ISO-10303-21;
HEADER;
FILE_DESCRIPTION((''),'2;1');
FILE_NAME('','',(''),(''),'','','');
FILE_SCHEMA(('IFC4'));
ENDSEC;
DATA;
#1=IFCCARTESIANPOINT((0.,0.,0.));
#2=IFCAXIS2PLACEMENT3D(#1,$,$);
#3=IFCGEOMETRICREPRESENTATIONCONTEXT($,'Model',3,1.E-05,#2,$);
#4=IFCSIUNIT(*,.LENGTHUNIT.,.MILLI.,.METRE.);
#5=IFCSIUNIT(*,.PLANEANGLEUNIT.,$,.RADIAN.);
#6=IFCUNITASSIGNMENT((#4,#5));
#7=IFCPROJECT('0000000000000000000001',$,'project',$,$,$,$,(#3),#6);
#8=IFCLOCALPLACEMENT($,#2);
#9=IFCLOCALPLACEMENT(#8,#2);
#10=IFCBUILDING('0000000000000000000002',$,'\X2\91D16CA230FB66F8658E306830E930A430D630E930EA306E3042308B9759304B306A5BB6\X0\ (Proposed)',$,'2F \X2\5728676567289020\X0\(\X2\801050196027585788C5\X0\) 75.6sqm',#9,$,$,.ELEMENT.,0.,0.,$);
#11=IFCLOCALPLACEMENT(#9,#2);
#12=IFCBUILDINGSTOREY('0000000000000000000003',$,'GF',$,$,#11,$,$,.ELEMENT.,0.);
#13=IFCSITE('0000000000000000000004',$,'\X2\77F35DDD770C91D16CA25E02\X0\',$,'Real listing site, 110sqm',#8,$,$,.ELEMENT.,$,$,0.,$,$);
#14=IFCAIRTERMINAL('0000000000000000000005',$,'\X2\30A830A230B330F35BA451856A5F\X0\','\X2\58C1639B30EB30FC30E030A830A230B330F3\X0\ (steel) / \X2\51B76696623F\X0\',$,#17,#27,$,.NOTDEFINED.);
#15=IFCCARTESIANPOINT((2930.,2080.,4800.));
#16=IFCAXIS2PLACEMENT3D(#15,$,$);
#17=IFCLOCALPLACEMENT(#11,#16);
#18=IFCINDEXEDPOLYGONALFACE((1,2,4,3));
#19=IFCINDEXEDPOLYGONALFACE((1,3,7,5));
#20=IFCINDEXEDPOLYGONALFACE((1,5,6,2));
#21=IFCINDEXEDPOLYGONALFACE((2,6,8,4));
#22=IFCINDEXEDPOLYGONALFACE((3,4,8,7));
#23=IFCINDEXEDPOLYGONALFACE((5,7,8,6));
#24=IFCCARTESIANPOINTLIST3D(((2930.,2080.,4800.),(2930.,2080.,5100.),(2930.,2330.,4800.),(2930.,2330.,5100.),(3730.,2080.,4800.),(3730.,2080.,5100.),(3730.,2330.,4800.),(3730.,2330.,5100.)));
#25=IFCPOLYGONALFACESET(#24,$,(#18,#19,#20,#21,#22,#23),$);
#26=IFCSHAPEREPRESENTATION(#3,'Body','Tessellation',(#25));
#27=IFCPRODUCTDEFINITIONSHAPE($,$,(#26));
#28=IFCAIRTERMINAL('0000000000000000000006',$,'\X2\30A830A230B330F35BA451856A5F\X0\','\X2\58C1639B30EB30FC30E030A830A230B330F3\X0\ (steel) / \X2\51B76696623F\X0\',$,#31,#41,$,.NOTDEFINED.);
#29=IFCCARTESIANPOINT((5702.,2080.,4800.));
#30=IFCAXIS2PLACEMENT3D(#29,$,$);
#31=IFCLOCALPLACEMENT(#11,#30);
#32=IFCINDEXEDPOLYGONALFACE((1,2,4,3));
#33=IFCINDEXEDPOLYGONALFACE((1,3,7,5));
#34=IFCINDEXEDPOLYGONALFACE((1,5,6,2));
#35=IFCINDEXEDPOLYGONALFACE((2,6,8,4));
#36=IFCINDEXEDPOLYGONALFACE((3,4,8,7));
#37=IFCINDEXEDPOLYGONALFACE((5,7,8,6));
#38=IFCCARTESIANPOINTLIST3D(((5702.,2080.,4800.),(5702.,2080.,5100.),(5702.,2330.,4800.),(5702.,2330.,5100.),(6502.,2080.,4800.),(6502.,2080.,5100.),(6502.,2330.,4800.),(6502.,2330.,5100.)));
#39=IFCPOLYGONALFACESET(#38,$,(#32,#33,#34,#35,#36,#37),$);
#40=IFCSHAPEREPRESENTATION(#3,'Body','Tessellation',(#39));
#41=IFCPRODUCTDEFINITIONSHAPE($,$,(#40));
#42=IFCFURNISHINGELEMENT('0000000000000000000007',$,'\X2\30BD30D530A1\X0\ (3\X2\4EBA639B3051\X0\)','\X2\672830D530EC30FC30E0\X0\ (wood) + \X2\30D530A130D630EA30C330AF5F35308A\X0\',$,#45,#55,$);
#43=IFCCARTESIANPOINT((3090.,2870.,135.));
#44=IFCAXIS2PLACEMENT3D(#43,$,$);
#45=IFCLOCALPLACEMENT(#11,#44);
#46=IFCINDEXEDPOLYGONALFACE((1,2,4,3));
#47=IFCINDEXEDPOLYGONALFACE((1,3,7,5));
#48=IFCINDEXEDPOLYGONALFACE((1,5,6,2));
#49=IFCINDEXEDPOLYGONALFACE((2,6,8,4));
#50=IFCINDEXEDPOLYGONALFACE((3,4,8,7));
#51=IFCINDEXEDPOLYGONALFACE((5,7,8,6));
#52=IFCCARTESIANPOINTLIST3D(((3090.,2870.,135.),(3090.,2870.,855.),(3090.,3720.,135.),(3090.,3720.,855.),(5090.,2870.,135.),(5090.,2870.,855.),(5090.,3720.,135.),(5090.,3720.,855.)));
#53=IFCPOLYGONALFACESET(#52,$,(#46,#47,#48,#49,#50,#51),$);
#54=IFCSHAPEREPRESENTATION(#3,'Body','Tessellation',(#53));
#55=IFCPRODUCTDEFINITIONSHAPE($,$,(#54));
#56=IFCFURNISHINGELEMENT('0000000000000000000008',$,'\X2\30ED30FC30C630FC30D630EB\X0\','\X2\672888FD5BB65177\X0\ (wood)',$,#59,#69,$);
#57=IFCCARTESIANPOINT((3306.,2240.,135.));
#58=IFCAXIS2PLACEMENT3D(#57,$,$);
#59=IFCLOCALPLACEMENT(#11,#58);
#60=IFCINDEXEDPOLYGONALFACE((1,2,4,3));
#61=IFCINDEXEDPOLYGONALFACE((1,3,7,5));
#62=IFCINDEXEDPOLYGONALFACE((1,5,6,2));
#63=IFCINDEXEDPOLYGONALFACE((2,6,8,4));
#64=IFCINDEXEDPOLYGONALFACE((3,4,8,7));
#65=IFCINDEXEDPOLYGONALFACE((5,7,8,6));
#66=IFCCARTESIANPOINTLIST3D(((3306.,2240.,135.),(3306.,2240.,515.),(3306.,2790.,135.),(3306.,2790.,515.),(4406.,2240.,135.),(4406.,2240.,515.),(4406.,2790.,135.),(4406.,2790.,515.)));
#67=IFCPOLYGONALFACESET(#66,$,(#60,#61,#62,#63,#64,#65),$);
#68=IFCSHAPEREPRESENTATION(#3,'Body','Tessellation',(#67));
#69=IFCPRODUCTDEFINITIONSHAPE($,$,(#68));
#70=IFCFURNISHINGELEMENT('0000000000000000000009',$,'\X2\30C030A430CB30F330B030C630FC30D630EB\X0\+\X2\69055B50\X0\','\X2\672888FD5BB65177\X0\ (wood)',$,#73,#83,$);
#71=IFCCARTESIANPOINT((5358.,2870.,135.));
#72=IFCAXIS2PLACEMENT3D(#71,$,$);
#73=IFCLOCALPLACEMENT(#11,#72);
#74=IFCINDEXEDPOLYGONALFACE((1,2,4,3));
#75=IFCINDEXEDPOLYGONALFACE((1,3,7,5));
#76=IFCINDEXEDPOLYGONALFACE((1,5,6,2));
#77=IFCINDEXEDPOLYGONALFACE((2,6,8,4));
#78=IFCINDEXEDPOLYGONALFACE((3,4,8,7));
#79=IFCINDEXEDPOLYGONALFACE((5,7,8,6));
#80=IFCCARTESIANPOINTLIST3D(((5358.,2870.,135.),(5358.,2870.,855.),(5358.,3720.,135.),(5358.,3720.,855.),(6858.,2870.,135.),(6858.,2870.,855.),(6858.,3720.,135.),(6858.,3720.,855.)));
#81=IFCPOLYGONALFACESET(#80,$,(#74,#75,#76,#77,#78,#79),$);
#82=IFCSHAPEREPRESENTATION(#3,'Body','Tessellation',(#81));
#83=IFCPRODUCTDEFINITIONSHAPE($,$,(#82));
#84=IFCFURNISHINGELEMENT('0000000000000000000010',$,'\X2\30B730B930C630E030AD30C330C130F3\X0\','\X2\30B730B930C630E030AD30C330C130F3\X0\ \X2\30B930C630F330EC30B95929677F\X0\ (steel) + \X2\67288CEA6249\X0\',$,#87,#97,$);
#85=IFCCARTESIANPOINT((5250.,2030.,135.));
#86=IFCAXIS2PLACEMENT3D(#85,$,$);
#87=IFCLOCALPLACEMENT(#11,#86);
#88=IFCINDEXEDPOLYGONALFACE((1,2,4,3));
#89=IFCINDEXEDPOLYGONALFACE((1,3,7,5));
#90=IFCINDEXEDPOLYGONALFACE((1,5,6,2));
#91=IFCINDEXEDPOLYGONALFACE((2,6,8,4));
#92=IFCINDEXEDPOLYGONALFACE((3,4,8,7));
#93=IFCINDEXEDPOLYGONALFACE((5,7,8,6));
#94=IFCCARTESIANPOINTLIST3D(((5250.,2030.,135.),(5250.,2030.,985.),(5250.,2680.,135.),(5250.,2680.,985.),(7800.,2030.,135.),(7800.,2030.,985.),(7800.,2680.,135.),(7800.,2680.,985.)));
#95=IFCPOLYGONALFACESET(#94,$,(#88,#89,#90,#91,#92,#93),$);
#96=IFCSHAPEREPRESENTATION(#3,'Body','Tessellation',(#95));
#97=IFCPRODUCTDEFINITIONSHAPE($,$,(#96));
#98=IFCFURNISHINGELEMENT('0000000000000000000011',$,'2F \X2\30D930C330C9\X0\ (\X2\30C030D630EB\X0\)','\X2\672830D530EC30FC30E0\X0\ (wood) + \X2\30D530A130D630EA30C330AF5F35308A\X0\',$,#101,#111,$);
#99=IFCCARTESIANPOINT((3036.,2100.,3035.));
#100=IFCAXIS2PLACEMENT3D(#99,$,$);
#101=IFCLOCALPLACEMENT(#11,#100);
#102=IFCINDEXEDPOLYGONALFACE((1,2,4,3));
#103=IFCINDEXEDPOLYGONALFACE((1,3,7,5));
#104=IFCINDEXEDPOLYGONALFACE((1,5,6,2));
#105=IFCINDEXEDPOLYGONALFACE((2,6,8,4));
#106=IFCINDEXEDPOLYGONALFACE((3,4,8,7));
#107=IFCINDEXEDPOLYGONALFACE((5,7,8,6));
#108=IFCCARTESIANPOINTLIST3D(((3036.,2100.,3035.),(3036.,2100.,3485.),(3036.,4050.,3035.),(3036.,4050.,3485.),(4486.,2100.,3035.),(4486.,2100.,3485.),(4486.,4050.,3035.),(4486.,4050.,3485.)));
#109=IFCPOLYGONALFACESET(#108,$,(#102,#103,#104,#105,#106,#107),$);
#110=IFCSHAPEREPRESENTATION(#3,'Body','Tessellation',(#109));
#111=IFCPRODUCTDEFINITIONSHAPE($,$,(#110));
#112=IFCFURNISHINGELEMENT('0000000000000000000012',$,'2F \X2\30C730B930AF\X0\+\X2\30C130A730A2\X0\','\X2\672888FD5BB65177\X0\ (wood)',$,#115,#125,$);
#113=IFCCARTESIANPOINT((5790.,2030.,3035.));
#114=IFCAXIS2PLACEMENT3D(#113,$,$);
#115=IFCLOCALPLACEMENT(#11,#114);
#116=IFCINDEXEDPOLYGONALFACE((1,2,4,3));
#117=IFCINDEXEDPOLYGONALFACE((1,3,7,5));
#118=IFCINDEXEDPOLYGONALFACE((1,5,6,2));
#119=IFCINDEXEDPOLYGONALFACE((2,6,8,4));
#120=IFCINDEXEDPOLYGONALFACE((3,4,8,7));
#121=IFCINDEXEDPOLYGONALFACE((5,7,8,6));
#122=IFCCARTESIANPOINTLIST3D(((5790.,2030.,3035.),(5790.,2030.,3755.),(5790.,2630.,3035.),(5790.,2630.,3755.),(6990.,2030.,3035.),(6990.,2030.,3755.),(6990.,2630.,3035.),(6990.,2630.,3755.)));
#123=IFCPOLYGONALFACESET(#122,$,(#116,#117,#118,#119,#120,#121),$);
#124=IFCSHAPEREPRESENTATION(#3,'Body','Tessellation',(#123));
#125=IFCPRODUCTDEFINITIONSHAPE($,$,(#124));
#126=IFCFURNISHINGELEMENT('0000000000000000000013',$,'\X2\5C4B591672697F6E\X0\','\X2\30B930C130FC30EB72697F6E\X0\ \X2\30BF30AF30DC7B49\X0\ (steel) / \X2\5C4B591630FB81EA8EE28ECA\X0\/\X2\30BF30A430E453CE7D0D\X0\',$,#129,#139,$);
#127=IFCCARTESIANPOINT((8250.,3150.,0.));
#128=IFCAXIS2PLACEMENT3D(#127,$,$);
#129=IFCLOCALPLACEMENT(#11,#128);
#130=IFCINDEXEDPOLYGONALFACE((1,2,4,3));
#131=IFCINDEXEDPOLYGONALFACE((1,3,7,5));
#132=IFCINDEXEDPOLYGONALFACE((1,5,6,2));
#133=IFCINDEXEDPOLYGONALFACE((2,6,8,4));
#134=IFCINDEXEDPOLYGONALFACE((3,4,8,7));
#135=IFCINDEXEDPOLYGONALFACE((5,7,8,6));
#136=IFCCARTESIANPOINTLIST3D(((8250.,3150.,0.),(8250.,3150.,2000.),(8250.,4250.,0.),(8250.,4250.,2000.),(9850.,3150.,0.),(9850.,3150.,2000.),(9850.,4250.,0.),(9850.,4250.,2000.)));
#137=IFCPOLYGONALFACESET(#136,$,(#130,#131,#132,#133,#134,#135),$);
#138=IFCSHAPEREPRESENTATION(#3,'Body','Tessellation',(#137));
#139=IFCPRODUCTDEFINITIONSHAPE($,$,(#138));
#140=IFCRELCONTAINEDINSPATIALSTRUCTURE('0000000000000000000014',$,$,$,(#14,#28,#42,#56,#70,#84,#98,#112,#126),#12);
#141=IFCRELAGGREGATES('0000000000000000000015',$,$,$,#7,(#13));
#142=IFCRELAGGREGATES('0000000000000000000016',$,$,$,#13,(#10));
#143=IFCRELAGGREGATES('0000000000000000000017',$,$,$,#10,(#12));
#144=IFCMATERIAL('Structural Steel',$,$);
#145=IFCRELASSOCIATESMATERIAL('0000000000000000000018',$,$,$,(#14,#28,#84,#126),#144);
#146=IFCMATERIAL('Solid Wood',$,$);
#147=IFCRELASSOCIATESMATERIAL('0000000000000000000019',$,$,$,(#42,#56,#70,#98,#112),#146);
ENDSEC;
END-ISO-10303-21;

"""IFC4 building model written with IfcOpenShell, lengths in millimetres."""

from ifc_helpers import new_model, si_unit, frame, frame_2d, origin, place, context, project, spatial, rectangle, extrude, material, element, save


model = new_model("IFC4")

# Units and contexts
model_context = context("Model", 3, precision=1e-05, world=origin())
ifc_project = project(units=[si_unit("LENGTHUNIT", "METRE", prefix="MILLI"), si_unit("PLANEANGLEUNIT", "RADIAN")], contexts=[model_context])

# Site, building, storey
site_placement = place(None, origin())
site = spatial("IfcSite", under=ifc_project, at=site_placement, Name="石川県金沢市", ObjectType="Real listing site, 110sqm", CompositionType="ELEMENT", RefElevation=0.0)
building_placement = place(site_placement, origin())
building = spatial("IfcBuilding", under=site, at=building_placement, Name="金沢・書斎とライブラリのある静かな家 (Proposed)", ObjectType="2F 在来木造(耐候性塗装) 75.6sqm", CompositionType="ELEMENT", ElevationOfRefHeight=0.0, ElevationOfTerrain=0.0)
storey_placement = place(building_placement, origin())
storey = spatial("IfcBuildingStorey", under=building, at=storey_placement, Name="GF", CompositionType="ELEMENT", Elevation=0.0)

# Shared definitions
ifc_material_1 = material(Name="Solid Wood")

# Shared definitions
ifc_material_2 = material(Name="Structural Steel")

# Air terminals
air_terminal_1_placement = place(storey_placement, frame((2930.0, 2080.0, 4800.0)))
element("IfcAirTerminal", 1, at=air_terminal_1_placement, inside=storey, material=ifc_material_2, Name="エアコン室内機", Description="壁掛ルームエアコン (steel) / 冷暖房", PredefinedType="NOTDEFINED", context=model_context, shape_type="SweptSolid", body=[
    extrude(rectangle(XDim=800.0, YDim=250.0, at=frame_2d((400.0, 125.0))), frame((2930.0, 2080.0, 4800.0)), (0.0, 0.0, 1.0), 300.0),
])
air_terminal_2_placement = place(storey_placement, frame((5702.0, 2080.0, 4800.0)))
element("IfcAirTerminal", 2, at=air_terminal_2_placement, inside=storey, material=ifc_material_2, Name="エアコン室内機", Description="壁掛ルームエアコン (steel) / 冷暖房", PredefinedType="NOTDEFINED", context=model_context, shape_type="SweptSolid", body=[
    extrude(rectangle(XDim=800.0, YDim=250.0, at=frame_2d((400.0, 125.0))), frame((5702.0, 2080.0, 4800.0)), (0.0, 0.0, 1.0), 300.0),
])

# Furnishing elements
furnishing_1_placement = place(storey_placement, frame((3090.0, 2870.0, 135.0)))
element("IfcFurnishingElement", 3, at=furnishing_1_placement, inside=storey, material=ifc_material_1, Name="ソファ (3人掛け)", Description="木フレーム (wood) + ファブリック張り", context=model_context, shape_type="SweptSolid", body=[
    extrude(rectangle(XDim=2000.0, YDim=850.0, at=frame_2d((1000.0, 425.0))), frame((3090.0, 2870.0, 135.0)), (0.0, 0.0, 1.0), 720.0),
])
furnishing_2_placement = place(storey_placement, frame((3306.0, 2240.0, 135.0)))
element("IfcFurnishingElement", 4, at=furnishing_2_placement, inside=storey, material=ifc_material_1, Name="ローテーブル", Description="木製家具 (wood)", context=model_context, shape_type="SweptSolid", body=[
    extrude(rectangle(XDim=1100.0, YDim=550.0, at=frame_2d((550.0, 275.0))), frame((3306.0, 2240.0, 135.0)), (0.0, 0.0, 1.0), 380.0),
])
furnishing_3_placement = place(storey_placement, frame((5358.0, 2870.0, 135.0)))
element("IfcFurnishingElement", 5, at=furnishing_3_placement, inside=storey, material=ifc_material_1, Name="ダイニングテーブル+椅子", Description="木製家具 (wood)", context=model_context, shape_type="SweptSolid", body=[
    extrude(rectangle(XDim=1500.0, YDim=850.0, at=frame_2d((750.0, 425.0))), frame((5358.0, 2870.0, 135.0)), (0.0, 0.0, 1.0), 720.0),
])
furnishing_4_placement = place(storey_placement, frame((5250.0, 2030.0, 135.0)))
element("IfcFurnishingElement", 6, at=furnishing_4_placement, inside=storey, material=ifc_material_2, Name="システムキッチン", Description="システムキッチン ステンレス天板 (steel) + 木質扉", context=model_context, shape_type="SweptSolid", body=[
    extrude(rectangle(XDim=2550.0, YDim=650.0, at=frame_2d((1275.0, 325.0))), frame((5250.0, 2030.0, 135.0)), (0.0, 0.0, 1.0), 850.0),
])
furnishing_5_placement = place(storey_placement, frame((3036.0, 2100.0, 3035.0)))
element("IfcFurnishingElement", 7, at=furnishing_5_placement, inside=storey, material=ifc_material_1, Name="2F ベッド (ダブル)", Description="木フレーム (wood) + ファブリック張り", context=model_context, shape_type="SweptSolid", body=[
    extrude(rectangle(XDim=1450.0, YDim=1950.0, at=frame_2d((725.0, 975.0))), frame((3036.0, 2100.0, 3035.0)), (0.0, 0.0, 1.0), 450.0),
])
furnishing_6_placement = place(storey_placement, frame((5790.0, 2030.0, 3035.0)))
element("IfcFurnishingElement", 8, at=furnishing_6_placement, inside=storey, material=ifc_material_1, Name="2F デスク+チェア", Description="木製家具 (wood)", context=model_context, shape_type="SweptSolid", body=[
    extrude(rectangle(XDim=1200.0, YDim=600.0, at=frame_2d((600.0, 300.0))), frame((5790.0, 2030.0, 3035.0)), (0.0, 0.0, 1.0), 720.0),
])
furnishing_7_placement = place(storey_placement, frame((8250.0, 3150.0, 0.0)))
element("IfcFurnishingElement", 9, at=furnishing_7_placement, inside=storey, material=ifc_material_2, Name="屋外物置", Description="スチール物置 タクボ等 (steel) / 屋外・自転車/タイヤ収納", context=model_context, shape_type="SweptSolid", body=[
    extrude(rectangle(XDim=1600.0, YDim=1100.0, at=frame_2d((800.0, 550.0))), frame((8250.0, 3150.0, 0.0)), (0.0, 0.0, 1.0), 2000.0),
])

save(model, "model.ifc")
